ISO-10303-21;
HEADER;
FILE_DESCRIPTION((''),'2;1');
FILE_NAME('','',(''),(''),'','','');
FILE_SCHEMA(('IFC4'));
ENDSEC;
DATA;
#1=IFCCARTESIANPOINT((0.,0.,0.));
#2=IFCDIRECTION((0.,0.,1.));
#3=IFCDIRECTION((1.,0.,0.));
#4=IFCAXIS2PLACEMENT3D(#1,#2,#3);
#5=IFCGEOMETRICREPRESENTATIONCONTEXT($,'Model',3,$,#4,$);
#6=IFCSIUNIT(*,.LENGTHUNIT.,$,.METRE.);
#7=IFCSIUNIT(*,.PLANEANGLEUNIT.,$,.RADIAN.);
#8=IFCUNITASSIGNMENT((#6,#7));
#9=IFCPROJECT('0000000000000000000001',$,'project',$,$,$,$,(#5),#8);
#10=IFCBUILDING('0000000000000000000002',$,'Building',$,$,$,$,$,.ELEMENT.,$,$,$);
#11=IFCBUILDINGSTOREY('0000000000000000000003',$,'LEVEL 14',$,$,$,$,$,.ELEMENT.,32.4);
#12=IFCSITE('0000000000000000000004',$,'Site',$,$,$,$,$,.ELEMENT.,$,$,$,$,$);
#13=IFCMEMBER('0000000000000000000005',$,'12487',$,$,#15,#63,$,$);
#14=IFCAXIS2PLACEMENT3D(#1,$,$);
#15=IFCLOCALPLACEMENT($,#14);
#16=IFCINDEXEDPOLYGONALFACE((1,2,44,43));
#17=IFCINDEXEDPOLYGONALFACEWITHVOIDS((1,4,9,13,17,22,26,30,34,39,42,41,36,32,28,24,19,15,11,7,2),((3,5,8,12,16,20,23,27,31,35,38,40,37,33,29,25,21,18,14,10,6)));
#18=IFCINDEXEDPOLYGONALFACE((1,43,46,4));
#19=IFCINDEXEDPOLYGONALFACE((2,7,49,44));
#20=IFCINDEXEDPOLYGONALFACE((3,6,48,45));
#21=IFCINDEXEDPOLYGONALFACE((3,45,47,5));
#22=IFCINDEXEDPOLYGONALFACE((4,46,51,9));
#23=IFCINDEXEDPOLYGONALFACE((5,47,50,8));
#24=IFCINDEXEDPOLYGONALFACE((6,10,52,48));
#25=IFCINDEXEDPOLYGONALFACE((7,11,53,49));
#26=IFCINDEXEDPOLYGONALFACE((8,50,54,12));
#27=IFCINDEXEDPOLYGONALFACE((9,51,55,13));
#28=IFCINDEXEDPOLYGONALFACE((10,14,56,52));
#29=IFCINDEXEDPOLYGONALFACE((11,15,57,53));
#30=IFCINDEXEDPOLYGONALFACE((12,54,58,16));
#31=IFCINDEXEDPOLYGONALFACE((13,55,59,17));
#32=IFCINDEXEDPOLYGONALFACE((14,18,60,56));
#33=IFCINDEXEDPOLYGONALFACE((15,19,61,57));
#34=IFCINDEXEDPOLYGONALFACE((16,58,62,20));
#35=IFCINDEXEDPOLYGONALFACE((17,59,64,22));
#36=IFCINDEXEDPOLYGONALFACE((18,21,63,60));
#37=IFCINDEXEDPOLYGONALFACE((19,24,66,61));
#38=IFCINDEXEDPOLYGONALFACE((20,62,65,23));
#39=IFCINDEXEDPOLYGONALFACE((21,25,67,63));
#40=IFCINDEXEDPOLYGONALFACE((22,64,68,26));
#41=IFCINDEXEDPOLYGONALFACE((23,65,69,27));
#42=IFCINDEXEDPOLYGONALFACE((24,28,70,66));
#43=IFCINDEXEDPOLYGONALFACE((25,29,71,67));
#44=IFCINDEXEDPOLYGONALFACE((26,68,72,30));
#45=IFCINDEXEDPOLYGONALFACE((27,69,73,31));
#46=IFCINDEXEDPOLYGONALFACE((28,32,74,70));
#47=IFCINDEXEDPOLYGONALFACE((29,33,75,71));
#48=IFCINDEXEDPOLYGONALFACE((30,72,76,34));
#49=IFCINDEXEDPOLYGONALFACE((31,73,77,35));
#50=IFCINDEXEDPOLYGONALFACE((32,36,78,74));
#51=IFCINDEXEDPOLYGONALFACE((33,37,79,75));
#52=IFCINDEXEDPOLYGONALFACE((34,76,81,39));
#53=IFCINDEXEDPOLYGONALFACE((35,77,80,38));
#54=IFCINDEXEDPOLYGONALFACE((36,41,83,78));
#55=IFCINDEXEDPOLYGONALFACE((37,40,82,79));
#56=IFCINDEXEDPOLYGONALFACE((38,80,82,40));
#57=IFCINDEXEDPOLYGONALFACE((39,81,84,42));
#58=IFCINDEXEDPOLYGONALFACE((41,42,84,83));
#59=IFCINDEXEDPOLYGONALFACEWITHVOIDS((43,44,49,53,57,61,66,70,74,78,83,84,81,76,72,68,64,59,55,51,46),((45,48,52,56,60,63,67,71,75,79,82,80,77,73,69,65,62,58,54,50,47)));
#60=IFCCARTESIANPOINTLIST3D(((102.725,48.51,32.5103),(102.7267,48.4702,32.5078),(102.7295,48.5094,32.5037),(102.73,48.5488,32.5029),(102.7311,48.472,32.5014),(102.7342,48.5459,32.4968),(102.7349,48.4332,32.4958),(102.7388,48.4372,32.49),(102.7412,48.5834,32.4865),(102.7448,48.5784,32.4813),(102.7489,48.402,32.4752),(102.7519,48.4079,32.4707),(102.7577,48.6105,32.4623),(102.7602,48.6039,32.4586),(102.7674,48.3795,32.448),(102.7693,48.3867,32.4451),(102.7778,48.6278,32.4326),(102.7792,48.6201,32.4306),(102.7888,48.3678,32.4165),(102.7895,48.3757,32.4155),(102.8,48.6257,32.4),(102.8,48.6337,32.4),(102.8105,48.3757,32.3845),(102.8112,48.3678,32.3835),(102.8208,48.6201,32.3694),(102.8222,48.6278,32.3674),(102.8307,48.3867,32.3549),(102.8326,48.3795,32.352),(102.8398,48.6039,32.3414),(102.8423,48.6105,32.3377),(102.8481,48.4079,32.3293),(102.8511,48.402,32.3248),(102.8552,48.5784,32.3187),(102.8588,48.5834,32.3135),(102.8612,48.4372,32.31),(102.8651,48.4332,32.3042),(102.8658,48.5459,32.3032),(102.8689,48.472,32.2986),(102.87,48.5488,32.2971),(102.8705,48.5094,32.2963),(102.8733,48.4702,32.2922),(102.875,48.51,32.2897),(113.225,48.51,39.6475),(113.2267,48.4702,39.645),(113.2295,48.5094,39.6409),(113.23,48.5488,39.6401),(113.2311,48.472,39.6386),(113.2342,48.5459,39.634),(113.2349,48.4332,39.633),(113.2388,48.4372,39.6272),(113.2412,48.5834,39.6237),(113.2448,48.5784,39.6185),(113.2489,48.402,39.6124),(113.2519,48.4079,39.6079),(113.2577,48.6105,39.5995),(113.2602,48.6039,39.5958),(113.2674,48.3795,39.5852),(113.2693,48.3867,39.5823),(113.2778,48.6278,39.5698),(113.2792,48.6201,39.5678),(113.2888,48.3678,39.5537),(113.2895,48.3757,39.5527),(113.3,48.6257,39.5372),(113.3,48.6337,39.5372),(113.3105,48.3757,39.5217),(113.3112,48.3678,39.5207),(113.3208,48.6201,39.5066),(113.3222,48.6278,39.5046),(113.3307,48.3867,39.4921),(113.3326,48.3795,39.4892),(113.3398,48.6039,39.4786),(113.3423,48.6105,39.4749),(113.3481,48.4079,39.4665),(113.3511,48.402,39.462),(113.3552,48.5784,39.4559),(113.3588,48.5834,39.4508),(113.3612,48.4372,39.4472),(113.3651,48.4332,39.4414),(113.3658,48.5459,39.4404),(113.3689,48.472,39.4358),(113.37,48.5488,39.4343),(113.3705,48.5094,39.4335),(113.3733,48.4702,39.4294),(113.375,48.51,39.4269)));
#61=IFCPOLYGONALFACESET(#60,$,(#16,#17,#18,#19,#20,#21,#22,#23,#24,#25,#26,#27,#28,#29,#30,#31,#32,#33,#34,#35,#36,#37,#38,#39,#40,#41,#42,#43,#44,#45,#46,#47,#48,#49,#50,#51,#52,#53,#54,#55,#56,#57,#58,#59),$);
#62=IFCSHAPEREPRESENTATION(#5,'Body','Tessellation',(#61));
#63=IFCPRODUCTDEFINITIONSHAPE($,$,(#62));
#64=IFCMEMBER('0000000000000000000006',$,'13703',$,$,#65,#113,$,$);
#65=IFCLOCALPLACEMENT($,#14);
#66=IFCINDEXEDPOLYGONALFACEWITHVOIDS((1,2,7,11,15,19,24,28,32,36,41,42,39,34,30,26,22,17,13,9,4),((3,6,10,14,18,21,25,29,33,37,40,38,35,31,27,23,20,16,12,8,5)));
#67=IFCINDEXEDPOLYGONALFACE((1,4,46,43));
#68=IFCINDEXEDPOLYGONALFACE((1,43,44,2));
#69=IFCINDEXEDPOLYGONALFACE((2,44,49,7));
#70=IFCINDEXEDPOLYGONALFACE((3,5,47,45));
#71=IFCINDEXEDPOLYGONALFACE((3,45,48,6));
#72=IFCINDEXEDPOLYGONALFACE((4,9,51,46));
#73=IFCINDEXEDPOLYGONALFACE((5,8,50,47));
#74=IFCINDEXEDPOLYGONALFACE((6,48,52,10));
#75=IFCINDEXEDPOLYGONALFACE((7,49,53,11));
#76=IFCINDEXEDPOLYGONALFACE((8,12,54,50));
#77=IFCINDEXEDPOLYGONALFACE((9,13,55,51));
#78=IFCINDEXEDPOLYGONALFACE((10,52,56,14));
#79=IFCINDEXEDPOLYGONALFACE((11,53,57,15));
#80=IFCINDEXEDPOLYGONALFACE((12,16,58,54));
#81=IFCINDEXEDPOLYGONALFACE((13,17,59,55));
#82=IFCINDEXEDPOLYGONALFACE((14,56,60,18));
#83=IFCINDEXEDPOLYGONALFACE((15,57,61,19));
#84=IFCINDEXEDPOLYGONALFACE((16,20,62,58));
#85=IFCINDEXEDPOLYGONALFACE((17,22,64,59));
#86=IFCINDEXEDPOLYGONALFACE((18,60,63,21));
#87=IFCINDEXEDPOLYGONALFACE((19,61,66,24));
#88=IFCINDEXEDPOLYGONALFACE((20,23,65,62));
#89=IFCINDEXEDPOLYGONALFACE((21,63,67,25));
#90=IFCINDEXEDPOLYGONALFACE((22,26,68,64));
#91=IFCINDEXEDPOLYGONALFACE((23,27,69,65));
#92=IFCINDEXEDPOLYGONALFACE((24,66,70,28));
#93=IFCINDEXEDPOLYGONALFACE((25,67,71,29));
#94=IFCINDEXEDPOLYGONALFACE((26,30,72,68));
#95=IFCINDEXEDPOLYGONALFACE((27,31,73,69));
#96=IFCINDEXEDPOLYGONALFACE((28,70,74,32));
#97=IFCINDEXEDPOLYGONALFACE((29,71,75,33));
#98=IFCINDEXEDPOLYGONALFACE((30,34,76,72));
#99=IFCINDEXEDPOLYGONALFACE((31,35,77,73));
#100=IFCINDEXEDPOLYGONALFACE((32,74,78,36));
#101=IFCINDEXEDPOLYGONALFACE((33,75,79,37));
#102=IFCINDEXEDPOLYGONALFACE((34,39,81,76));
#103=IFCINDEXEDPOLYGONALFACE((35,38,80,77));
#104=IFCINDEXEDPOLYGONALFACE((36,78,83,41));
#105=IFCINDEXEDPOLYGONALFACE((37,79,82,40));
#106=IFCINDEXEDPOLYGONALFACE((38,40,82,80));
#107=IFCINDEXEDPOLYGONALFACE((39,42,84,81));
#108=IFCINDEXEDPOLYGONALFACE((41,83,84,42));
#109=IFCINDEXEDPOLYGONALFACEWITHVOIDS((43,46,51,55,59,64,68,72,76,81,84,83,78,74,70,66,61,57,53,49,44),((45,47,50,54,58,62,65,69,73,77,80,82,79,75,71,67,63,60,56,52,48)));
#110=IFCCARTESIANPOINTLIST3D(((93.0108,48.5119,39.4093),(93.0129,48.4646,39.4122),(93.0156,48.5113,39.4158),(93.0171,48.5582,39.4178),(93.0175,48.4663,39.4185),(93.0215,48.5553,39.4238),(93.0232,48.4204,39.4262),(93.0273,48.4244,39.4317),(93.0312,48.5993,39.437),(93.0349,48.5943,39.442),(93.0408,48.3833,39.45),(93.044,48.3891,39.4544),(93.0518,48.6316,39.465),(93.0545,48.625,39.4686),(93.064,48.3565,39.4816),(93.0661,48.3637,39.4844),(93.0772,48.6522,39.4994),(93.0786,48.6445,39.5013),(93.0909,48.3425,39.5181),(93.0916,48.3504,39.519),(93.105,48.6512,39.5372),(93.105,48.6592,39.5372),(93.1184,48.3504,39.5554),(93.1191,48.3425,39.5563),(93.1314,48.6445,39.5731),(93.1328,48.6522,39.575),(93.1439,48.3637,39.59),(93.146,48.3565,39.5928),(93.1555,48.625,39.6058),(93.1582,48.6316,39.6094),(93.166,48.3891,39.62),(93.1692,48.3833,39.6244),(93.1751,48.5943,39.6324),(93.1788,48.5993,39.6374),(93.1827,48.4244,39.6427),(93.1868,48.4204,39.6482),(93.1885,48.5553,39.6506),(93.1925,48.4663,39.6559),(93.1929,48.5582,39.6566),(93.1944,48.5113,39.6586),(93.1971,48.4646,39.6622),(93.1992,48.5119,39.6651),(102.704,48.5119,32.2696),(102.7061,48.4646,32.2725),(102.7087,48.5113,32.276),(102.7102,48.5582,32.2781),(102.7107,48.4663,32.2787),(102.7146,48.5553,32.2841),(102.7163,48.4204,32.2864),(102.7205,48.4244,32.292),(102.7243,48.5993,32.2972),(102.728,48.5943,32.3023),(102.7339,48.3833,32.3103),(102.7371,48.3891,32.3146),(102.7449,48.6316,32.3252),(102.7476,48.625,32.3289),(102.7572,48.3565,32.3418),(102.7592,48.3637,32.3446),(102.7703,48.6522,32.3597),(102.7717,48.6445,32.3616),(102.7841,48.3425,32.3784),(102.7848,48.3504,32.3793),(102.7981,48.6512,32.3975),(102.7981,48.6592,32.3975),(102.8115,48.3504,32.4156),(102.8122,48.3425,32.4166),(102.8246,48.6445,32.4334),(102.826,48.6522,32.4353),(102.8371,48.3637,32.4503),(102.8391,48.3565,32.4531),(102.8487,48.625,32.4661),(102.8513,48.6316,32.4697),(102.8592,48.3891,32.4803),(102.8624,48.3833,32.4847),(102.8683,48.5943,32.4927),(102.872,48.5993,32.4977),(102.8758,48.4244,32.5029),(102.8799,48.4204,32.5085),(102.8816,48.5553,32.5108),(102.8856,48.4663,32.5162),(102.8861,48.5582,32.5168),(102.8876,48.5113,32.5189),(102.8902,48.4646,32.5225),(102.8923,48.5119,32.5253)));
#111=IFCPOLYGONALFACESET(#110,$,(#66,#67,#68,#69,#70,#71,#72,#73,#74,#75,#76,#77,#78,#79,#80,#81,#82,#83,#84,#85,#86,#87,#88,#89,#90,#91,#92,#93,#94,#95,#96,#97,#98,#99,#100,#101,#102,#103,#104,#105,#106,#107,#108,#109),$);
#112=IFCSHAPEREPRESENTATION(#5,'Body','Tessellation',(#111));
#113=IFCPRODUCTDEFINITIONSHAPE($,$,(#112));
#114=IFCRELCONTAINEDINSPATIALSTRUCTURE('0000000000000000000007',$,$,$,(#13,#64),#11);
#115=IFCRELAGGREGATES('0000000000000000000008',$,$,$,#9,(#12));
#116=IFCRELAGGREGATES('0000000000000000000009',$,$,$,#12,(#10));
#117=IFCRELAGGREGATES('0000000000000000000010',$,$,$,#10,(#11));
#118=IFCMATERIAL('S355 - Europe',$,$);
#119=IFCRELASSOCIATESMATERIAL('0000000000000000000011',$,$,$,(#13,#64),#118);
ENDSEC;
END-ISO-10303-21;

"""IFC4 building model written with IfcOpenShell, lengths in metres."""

from ifc_helpers import new_model, si_unit, frame, origin_with_axes, origin_2d_with_axis, place, context, project, spatial, hollow_circle, extrude, material, material_profile, profile_set, profile_usage, element, save


model = new_model("IFC4")

# Units and contexts
model_context = context("Model", 3, world=origin_with_axes())
ifc_project = project(units=[si_unit("LENGTHUNIT", "METRE"), si_unit("PLANEANGLEUNIT", "RADIAN")], contexts=[model_context])

# Site, building, storey
site = spatial("IfcSite", under=ifc_project, Name="Site", CompositionType="ELEMENT")
building = spatial("IfcBuilding", under=site, Name="Building", CompositionType="ELEMENT")
storey = spatial("IfcBuildingStorey", under=building, Name="LEVEL 14", CompositionType="ELEMENT", Elevation=32.4)

# Shared definitions
ifc_material = material(Name="S355 - Europe")

# Members
ifc_material_profile_1 = material_profile(ifc_material, hollow_circle(Radius=0.1337, WallThickness=0.008, at=origin_2d_with_axis()))
ifc_profile_set_1 = profile_set([ifc_material_profile_1])
ifc_profile_usage_1 = profile_usage(ifc_profile_set_1, cardinal=10)
member_1_placement = place(None, frame((102.8, 48.5, 32.4), z_axis=(0.827029, 0.0, 0.562159), x_axis=(0.0, 1.0, 0.0)))
element("IfcMember", 1, at=member_1_placement, inside=storey, material=ifc_profile_usage_1, Name="12487", context=model_context, shape_type="SweptSolid", body=[
    extrude(hollow_circle(Radius=0.1337, WallThickness=0.008, at=origin_2d_with_axis()), origin_with_axes(), (0.0, 0.0, 1.0), 12.696),
])
ifc_material_profile_2 = material_profile(ifc_material, hollow_circle(Radius=0.1593, WallThickness=0.008, at=origin_2d_with_axis()))
ifc_profile_set_2 = profile_set([ifc_material_profile_2])
ifc_profile_usage_2 = profile_usage(ifc_profile_set_2, cardinal=10)
member_2_placement = place(None, frame((93.105, 48.5, 39.5372), z_axis=(0.805159, 0.0, -0.59306), x_axis=(0.0, 1.0, 0.0)))
element("IfcMember", 2, at=member_2_placement, inside=storey, material=ifc_profile_usage_2, Name="13703", context=model_context, shape_type="SweptSolid", body=[
    extrude(hollow_circle(Radius=0.1593, WallThickness=0.008, at=origin_2d_with_axis()), origin_with_axes(), (0.0, 0.0, 1.0), 12.0388),
])

save(model, "model.ifc")
